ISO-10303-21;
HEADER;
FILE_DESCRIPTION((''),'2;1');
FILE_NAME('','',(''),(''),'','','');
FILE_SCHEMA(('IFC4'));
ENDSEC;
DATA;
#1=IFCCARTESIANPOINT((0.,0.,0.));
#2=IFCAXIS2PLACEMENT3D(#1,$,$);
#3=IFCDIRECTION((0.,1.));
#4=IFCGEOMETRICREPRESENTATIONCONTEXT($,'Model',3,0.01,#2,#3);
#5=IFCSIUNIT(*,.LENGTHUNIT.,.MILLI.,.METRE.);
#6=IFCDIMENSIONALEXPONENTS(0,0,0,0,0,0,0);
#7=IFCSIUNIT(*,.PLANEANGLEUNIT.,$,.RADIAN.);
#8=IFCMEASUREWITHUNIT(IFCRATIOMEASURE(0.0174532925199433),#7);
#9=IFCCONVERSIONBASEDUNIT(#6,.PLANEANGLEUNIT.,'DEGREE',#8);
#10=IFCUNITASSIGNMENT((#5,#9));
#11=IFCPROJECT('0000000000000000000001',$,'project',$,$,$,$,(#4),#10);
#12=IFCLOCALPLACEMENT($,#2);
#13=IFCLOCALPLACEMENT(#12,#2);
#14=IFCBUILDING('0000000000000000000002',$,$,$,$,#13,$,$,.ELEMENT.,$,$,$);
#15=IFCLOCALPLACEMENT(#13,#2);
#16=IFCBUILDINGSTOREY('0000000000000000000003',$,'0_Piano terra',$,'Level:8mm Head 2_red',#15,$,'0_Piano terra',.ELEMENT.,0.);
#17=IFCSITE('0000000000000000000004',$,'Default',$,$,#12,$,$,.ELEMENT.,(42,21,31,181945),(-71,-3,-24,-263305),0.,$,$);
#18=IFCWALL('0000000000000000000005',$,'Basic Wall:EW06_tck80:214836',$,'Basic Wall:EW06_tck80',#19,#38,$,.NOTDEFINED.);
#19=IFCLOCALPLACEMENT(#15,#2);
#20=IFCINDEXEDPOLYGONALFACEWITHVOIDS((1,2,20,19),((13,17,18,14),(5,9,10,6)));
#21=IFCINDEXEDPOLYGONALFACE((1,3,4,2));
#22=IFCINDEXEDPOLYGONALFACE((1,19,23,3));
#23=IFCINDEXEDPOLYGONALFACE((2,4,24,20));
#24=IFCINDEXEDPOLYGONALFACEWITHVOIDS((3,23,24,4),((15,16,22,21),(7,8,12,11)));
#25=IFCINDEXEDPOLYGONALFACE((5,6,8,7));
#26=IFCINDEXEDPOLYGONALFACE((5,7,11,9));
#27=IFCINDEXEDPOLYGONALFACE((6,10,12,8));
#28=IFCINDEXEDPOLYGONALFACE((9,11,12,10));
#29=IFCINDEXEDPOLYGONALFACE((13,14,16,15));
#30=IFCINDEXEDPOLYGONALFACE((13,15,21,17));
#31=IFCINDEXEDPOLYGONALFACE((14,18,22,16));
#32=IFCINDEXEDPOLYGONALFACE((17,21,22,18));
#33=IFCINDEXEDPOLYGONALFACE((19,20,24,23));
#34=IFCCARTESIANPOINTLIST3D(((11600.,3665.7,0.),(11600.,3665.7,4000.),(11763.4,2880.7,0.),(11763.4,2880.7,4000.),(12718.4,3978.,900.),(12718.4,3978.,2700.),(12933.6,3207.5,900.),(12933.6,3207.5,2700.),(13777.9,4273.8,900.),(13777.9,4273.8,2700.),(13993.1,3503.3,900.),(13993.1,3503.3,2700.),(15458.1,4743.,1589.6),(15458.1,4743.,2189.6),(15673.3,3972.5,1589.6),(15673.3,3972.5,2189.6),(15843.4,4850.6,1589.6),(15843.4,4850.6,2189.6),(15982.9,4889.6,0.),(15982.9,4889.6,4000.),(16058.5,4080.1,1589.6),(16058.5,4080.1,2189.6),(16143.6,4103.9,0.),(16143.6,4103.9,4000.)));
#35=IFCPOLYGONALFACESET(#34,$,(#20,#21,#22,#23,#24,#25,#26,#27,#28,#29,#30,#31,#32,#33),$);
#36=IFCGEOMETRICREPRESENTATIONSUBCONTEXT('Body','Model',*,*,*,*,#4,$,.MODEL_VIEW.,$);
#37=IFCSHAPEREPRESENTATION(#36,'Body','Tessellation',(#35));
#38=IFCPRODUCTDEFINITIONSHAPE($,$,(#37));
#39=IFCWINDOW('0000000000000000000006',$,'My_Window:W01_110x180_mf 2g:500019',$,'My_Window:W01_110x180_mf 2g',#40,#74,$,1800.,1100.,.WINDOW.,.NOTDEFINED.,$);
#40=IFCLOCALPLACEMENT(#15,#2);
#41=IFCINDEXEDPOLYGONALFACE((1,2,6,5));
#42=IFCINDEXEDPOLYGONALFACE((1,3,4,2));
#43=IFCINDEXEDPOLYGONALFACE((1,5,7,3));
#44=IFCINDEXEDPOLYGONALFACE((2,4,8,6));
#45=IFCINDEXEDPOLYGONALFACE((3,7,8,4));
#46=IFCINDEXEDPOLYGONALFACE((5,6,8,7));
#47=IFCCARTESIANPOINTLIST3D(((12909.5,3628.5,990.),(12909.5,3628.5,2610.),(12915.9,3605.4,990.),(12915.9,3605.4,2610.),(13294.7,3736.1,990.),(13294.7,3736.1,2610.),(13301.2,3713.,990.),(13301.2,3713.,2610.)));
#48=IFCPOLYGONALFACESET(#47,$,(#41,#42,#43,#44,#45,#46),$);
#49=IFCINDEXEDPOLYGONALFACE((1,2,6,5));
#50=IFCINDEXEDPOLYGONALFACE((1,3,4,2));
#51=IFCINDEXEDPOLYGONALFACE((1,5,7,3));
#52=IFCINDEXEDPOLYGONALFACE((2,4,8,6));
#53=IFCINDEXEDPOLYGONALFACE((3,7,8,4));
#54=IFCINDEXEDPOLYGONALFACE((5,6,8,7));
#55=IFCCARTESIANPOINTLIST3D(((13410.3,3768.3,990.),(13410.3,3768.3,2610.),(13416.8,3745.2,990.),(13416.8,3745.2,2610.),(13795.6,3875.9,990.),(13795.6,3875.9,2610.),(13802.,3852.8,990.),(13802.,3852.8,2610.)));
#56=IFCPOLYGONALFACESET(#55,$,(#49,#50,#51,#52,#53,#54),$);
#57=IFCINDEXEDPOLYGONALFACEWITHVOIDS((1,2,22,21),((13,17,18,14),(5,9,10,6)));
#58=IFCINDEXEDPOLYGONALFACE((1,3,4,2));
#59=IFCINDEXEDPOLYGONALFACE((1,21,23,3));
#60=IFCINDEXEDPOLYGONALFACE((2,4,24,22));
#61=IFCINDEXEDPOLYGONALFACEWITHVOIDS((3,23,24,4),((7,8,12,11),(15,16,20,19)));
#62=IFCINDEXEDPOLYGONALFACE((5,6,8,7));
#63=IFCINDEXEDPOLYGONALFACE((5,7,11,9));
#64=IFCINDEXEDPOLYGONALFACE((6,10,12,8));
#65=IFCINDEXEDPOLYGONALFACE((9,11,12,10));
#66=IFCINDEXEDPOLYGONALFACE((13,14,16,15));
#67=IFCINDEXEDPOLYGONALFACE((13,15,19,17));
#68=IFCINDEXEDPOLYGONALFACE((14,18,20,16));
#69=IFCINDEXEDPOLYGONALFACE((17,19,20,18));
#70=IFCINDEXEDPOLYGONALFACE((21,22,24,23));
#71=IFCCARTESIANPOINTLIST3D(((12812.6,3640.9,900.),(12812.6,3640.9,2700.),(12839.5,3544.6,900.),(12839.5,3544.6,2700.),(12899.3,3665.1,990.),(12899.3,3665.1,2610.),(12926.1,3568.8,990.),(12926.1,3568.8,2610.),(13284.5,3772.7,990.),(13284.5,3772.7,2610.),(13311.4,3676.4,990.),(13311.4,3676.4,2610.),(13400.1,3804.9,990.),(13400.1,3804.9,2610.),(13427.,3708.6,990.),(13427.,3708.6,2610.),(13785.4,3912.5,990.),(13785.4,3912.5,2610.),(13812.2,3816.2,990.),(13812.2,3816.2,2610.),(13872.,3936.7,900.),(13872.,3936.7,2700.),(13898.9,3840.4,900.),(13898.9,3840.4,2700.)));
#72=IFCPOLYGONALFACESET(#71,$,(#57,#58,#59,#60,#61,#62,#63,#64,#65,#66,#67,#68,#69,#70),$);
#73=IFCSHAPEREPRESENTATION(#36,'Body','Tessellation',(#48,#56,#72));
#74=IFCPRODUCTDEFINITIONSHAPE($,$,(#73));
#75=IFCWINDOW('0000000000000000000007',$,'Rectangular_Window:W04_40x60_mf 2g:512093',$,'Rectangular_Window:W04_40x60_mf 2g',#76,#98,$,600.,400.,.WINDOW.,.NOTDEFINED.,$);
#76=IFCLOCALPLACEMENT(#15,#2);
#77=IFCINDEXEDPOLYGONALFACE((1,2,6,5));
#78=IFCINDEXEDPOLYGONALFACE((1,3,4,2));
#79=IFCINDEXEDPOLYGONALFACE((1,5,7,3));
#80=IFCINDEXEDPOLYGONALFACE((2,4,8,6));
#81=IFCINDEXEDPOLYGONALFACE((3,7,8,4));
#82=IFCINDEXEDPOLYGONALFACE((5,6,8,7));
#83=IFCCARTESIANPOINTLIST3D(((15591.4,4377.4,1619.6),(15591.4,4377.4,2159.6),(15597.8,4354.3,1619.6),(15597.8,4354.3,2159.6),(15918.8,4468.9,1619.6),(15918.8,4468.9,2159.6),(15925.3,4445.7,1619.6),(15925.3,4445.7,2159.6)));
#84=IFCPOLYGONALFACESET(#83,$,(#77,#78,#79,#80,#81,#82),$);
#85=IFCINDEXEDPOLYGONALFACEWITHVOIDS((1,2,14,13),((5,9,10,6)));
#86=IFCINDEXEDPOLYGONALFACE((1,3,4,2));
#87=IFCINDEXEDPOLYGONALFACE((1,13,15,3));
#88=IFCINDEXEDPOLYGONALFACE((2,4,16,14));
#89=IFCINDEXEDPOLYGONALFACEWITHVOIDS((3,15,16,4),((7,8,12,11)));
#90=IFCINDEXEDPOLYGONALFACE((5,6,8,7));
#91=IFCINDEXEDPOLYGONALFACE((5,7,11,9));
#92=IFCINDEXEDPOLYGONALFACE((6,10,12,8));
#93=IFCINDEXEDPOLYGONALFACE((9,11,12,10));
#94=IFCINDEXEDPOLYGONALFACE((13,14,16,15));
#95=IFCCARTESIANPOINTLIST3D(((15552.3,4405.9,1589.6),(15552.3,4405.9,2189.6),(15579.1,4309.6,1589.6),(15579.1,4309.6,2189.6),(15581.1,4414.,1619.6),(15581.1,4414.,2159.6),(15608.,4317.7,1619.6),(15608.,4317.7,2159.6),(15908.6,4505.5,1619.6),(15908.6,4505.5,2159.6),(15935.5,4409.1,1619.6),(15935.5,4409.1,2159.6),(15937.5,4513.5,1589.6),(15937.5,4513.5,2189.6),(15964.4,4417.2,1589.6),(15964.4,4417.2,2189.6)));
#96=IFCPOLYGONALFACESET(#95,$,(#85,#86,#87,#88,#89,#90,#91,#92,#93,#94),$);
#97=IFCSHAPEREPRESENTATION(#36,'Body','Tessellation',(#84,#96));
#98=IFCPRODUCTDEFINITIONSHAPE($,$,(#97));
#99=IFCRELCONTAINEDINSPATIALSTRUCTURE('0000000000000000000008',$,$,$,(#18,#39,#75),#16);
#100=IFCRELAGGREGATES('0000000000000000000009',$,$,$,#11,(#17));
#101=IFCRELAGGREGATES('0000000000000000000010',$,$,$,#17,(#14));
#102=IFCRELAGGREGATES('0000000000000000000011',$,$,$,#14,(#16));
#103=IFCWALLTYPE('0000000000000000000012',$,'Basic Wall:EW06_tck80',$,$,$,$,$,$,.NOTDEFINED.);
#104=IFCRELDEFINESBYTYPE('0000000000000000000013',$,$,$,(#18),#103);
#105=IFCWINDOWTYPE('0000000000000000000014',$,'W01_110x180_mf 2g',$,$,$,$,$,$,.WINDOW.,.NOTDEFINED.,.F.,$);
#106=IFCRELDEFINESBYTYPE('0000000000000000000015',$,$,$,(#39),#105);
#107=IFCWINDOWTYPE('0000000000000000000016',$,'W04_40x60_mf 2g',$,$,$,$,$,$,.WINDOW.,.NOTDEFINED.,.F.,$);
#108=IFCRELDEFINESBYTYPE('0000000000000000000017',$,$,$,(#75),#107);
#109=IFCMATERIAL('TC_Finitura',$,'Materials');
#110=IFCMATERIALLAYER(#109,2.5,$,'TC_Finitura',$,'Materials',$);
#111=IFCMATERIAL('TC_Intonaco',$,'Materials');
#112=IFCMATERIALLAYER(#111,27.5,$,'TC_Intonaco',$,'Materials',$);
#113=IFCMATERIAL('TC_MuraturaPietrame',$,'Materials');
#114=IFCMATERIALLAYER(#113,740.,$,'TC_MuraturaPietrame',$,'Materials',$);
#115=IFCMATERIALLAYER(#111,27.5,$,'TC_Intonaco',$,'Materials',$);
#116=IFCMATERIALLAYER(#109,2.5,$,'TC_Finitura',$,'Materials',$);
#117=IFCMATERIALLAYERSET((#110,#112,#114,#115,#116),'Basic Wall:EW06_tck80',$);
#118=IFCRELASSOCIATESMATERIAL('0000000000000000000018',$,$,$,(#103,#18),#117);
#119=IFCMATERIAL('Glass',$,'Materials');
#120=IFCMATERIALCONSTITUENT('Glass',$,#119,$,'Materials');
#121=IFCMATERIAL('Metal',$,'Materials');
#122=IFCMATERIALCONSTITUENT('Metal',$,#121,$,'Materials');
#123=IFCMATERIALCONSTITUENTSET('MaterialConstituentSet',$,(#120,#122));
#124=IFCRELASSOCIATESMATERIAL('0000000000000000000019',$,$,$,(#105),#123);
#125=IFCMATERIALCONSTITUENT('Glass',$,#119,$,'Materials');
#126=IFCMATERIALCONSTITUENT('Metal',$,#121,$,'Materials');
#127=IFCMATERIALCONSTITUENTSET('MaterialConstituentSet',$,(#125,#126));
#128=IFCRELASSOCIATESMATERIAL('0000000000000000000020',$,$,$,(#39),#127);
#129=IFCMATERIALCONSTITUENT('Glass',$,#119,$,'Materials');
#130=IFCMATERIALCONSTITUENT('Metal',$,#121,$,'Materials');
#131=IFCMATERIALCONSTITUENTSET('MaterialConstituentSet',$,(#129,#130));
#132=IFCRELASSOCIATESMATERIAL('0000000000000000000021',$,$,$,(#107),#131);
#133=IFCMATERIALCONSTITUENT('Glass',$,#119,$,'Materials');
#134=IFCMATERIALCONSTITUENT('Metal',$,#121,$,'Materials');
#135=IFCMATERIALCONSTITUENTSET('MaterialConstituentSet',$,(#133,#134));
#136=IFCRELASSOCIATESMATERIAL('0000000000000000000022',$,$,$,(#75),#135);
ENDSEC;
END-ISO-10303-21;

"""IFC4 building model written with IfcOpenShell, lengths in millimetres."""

from ifc_helpers import new_model, entity, si_unit, converted_unit, direction, frame, frame_2d, origin, origin_2d_with_axis, place, context, subcontext, project, spatial, polyline, rectangle, outline, extrude, clip, bounded_halfspace, source, transform, mapped, material, layer, layer_set, layer_usage, constituent, constituent_set, type_object, type_shapes, element, fill, save


model = new_model("IFC4")

# Units and contexts
model_context = context("Model", 3, precision=0.01, world=origin(), true_north=direction((0.0, 1.0)))
body_context = subcontext(model_context, "Body", "Model", "MODEL_VIEW")
ifc_project = project(units=[si_unit("LENGTHUNIT", "METRE", prefix="MILLI"), converted_unit("PLANEANGLEUNIT", "DEGREE", entity("IfcRatioMeasure", 0.0174532925199433), si_unit("PLANEANGLEUNIT", "RADIAN"), dimensions=[0, 0, 0, 0, 0, 0, 0])], contexts=[model_context])

# Site, building, storey
site_placement = place(None, origin())
site = spatial("IfcSite", under=ifc_project, at=site_placement, Name="Default", CompositionType="ELEMENT", RefLatitude=(42, 21, 31, 181945), RefLongitude=(-71, -3, -24, -263305), RefElevation=0.0)
building_placement = place(site_placement, origin())
building = spatial("IfcBuilding", under=site, at=building_placement, CompositionType="ELEMENT")
storey_placement = place(building_placement, origin())
storey = spatial("IfcBuildingStorey", under=building, at=storey_placement, Name="0_Piano terra", ObjectType="Level:8mm Head 2_red", LongName="0_Piano terra", CompositionType="ELEMENT", Elevation=0.0)

# Shared definitions
ifc_material_1 = material(Name="TC_Finitura", Category="Materials")
ifc_layer_1 = layer(ifc_material_1, 2.5, Name="TC_Finitura", Category="Materials")
ifc_material_2 = material(Name="TC_Intonaco", Category="Materials")
ifc_layer_2 = layer(ifc_material_2, 27.5, Name="TC_Intonaco", Category="Materials")
ifc_material_3 = material(Name="TC_MuraturaPietrame", Category="Materials")
ifc_layer_3 = layer(ifc_material_3, 740.0, Name="TC_MuraturaPietrame", Category="Materials")
ifc_layer_4 = layer(ifc_material_2, 27.5, Name="TC_Intonaco", Category="Materials")
ifc_layer_5 = layer(ifc_material_1, 2.5, Name="TC_Finitura", Category="Materials")
ifc_layer_set_1 = layer_set([ifc_layer_1, ifc_layer_2, ifc_layer_3, ifc_layer_4, ifc_layer_5], Name="Basic Wall:EW06_tck80")
wall_type_1 = type_object("IfcWallType", Name="Basic Wall:EW06_tck80", PredefinedType="NOTDEFINED", material=ifc_layer_set_1)
ifc_material_4 = material(Name="Glass", Category="Materials")
ifc_material_5 = material(Name="Metal", Category="Materials")

# Wall, openings, windows
ifc_layer_usage_1 = layer_usage(ifc_layer_set_1, "AXIS2", "NEGATIVE", 400.0)
wall_1_placement = place(storey_placement, frame((11655.8, 3265.9, 0.0), z_axis=(0.0, 0.0, 1.0), x_axis=(0.963151, 0.268962, 0.0)))
wall_1 = element("IfcWall", 1, at=wall_1_placement, inside=storey, type_object=wall_type_1, material=ifc_layer_usage_1, Name="Basic Wall:EW06_tck80:214836", ObjectType="Basic Wall:EW06_tck80", PredefinedType="NOTDEFINED", context=body_context, shape_type="Clipping", body=[
    clip(clip(extrude(outline(polyline([(4547.8, -400.0), (4604.4, 400.0), (53.8, 400.0), (0.0, -400.0), (4547.8, -400.0)])), origin(), (0.0, 0.0, 1.0), 4000.0), bounded_halfspace(frame((0.0, -400.0, 4000.0), z_axis=(0.0, 0.0, -1.0), x_axis=(0.006309, -0.99998, 0.0)), True, frame((0.0, -400.0, 4000.0)), polyline([(0.0, 0.0), (4547.8, 0.0), (4604.4, 800.0), (53.8, 800.0), (0.0, 0.0)]))), bounded_halfspace(frame((0.0, -400.0, 0.0), z_axis=(0.997749, -0.067055, 0.0), x_axis=(0.067055, 0.997749, 0.0)), True, frame((0.0, -400.0, 0.0), z_axis=(0.997749, -0.067055, 0.0), x_axis=(0.067055, 0.997749, 0.0)), polyline([(0.0, 0.0), (801.8, 0.0), (801.8, 4000.0), (0.0, 4000.0), (0.0, 0.0)]))),
])
opening_1_placement = place(wall_1_placement, frame((1215.0, -400.0, 900.0)))
opening_1 = element("IfcOpeningElement", 2, at=opening_1_placement, cuts=wall_1, ObjectType="Opening", PredefinedType="OPENING", context=body_context, shape_type="SweptSolid", body=[
    extrude(rectangle(XDim=1800.0, YDim=1100.0, at=frame_2d((900.0, 550.0), x_axis=(-1.0, 0.0))), frame((0.0, 0.0, 0.0), z_axis=(0.0, 1.0, 0.0), x_axis=(0.0, 0.0, 1.0)), (0.0, 0.0, 1.0), 800.0),
])
opening_2_placement = place(wall_1_placement, frame((4059.5, -400.0, 1589.6)))
opening_2 = element("IfcOpeningElement", 3, at=opening_2_placement, cuts=wall_1, ObjectType="Opening", PredefinedType="OPENING", context=body_context, shape_type="SweptSolid", body=[
    extrude(rectangle(XDim=600.0, YDim=400.0, at=frame_2d((300.0, 200.0), x_axis=(-1.0, 0.0))), frame((0.0, 0.0, 0.0), z_axis=(0.0, 1.0, 0.0), x_axis=(0.0, 0.0, 1.0)), (0.0, 0.0, 1.0), 800.0),
])
ifc_constituent_1 = constituent(ifc_material_4, Name="Glass", Category="Materials")
ifc_constituent_2 = constituent(ifc_material_5, Name="Metal", Category="Materials")
ifc_constituent_set_1 = constituent_set(constituents=[ifc_constituent_1, ifc_constituent_2], Name="MaterialConstituentSet")
ifc_constituent_3 = constituent(ifc_material_4, Name="Glass", Category="Materials")
ifc_constituent_4 = constituent(ifc_material_5, Name="Metal", Category="Materials")
ifc_constituent_set_2 = constituent_set(constituents=[ifc_constituent_3, ifc_constituent_4], Name="MaterialConstituentSet")
window_type_1 = type_object("IfcWindowType", Name="W01_110x180_mf 2g", ParameterTakesPrecedence=False, PartitioningType="NOTDEFINED", PredefinedType="WINDOW", material=ifc_constituent_set_2)
shared_shape_1 = source(origin(), body_context, "Body", "SweptSolid", [
    extrude(rectangle(XDim=24.0, YDim=400.0, at=origin_2d_with_axis()), frame((290.0, 400.0, 90.0), z_axis=(0.0, 0.0, 1.0), x_axis=(0.0, 1.0, 0.0)), (0.0, 0.0, 1.0), 1620.0),
    extrude(rectangle(XDim=24.0, YDim=400.0, at=origin_2d_with_axis()), frame((810.0, 400.0, 90.0), z_axis=(0.0, 0.0, 1.0), x_axis=(0.0, 1.0, 0.0)), (0.0, 0.0, 1.0), 1620.0),
    extrude(outline(polyline([(-550.0, -900.0), (550.0, -900.0), (550.0, 900.0), (-550.0, 900.0), (-550.0, -900.0)]), holes=[polyline([(-60.0, -810.0), (-460.0, -810.0), (-460.0, 810.0), (-60.0, 810.0), (-60.0, -810.0)]), polyline([(460.0, -810.0), (60.0, -810.0), (60.0, 810.0), (460.0, 810.0), (460.0, -810.0)])]), frame((550.0, 350.0, 900.0), z_axis=(0.0, 1.0, 0.0), x_axis=(1.0, 0.0, 0.0)), (0.0, 0.0, 1.0), 100.0),
])
type_shapes(window_type_1, [shared_shape_1])
window_1_placement = place(opening_1_placement, origin())
window_1 = element("IfcWindow", 4, at=window_1_placement, inside=storey, type_object=window_type_1, material=ifc_constituent_set_1, Name="My_Window:W01_110x180_mf 2g:500019", ObjectType="My_Window:W01_110x180_mf 2g", OverallHeight=1800.0, OverallWidth=1100.0, PartitioningType="NOTDEFINED", PredefinedType="WINDOW", context=body_context, shape_type="MappedRepresentation", body=[
    mapped(shared_shape_1, transform((0.0, 0.0, 0.0), scale=1.0)),
])
fill(opening_1, window_1)
ifc_constituent_5 = constituent(ifc_material_4, Name="Glass", Category="Materials")
ifc_constituent_6 = constituent(ifc_material_5, Name="Metal", Category="Materials")
ifc_constituent_set_3 = constituent_set(constituents=[ifc_constituent_5, ifc_constituent_6], Name="MaterialConstituentSet")
ifc_constituent_7 = constituent(ifc_material_4, Name="Glass", Category="Materials")
ifc_constituent_8 = constituent(ifc_material_5, Name="Metal", Category="Materials")
ifc_constituent_set_4 = constituent_set(constituents=[ifc_constituent_7, ifc_constituent_8], Name="MaterialConstituentSet")
window_type_2 = type_object("IfcWindowType", Name="W04_40x60_mf 2g", ParameterTakesPrecedence=False, PartitioningType="NOTDEFINED", PredefinedType="WINDOW", material=ifc_constituent_set_4)
shared_shape_2 = source(origin(), body_context, "Body", "SweptSolid", [
    extrude(rectangle(XDim=24.0, YDim=340.0, at=origin_2d_with_axis()), frame((200.0, 400.0, 30.0), z_axis=(0.0, 0.0, 1.0), x_axis=(0.0, 1.0, 0.0)), (0.0, 0.0, 1.0), 540.0),
    extrude(outline(polyline([(-200.0, -300.0), (200.0, -300.0), (200.0, 300.0), (-200.0, 300.0), (-200.0, -300.0)]), holes=[polyline([(-170.0, -270.0), (-170.0, 270.0), (170.0, 270.0), (170.0, -270.0), (-170.0, -270.0)])]), frame((200.0, 350.0, 300.0), z_axis=(0.0, 1.0, 0.0), x_axis=(1.0, 0.0, 0.0)), (0.0, 0.0, 1.0), 100.0),
])
type_shapes(window_type_2, [shared_shape_2])
window_2_placement = place(opening_2_placement, origin())
window_2 = element("IfcWindow", 5, at=window_2_placement, inside=storey, type_object=window_type_2, material=ifc_constituent_set_3, Name="Rectangular_Window:W04_40x60_mf 2g:512093", ObjectType="Rectangular_Window:W04_40x60_mf 2g", OverallHeight=600.0, OverallWidth=400.0, PartitioningType="NOTDEFINED", PredefinedType="WINDOW", context=body_context, shape_type="MappedRepresentation", body=[
    mapped(shared_shape_2, transform((0.0, 0.0, 0.0), scale=1.0)),
])
fill(opening_2, window_2)

save(model, "model.ifc")
